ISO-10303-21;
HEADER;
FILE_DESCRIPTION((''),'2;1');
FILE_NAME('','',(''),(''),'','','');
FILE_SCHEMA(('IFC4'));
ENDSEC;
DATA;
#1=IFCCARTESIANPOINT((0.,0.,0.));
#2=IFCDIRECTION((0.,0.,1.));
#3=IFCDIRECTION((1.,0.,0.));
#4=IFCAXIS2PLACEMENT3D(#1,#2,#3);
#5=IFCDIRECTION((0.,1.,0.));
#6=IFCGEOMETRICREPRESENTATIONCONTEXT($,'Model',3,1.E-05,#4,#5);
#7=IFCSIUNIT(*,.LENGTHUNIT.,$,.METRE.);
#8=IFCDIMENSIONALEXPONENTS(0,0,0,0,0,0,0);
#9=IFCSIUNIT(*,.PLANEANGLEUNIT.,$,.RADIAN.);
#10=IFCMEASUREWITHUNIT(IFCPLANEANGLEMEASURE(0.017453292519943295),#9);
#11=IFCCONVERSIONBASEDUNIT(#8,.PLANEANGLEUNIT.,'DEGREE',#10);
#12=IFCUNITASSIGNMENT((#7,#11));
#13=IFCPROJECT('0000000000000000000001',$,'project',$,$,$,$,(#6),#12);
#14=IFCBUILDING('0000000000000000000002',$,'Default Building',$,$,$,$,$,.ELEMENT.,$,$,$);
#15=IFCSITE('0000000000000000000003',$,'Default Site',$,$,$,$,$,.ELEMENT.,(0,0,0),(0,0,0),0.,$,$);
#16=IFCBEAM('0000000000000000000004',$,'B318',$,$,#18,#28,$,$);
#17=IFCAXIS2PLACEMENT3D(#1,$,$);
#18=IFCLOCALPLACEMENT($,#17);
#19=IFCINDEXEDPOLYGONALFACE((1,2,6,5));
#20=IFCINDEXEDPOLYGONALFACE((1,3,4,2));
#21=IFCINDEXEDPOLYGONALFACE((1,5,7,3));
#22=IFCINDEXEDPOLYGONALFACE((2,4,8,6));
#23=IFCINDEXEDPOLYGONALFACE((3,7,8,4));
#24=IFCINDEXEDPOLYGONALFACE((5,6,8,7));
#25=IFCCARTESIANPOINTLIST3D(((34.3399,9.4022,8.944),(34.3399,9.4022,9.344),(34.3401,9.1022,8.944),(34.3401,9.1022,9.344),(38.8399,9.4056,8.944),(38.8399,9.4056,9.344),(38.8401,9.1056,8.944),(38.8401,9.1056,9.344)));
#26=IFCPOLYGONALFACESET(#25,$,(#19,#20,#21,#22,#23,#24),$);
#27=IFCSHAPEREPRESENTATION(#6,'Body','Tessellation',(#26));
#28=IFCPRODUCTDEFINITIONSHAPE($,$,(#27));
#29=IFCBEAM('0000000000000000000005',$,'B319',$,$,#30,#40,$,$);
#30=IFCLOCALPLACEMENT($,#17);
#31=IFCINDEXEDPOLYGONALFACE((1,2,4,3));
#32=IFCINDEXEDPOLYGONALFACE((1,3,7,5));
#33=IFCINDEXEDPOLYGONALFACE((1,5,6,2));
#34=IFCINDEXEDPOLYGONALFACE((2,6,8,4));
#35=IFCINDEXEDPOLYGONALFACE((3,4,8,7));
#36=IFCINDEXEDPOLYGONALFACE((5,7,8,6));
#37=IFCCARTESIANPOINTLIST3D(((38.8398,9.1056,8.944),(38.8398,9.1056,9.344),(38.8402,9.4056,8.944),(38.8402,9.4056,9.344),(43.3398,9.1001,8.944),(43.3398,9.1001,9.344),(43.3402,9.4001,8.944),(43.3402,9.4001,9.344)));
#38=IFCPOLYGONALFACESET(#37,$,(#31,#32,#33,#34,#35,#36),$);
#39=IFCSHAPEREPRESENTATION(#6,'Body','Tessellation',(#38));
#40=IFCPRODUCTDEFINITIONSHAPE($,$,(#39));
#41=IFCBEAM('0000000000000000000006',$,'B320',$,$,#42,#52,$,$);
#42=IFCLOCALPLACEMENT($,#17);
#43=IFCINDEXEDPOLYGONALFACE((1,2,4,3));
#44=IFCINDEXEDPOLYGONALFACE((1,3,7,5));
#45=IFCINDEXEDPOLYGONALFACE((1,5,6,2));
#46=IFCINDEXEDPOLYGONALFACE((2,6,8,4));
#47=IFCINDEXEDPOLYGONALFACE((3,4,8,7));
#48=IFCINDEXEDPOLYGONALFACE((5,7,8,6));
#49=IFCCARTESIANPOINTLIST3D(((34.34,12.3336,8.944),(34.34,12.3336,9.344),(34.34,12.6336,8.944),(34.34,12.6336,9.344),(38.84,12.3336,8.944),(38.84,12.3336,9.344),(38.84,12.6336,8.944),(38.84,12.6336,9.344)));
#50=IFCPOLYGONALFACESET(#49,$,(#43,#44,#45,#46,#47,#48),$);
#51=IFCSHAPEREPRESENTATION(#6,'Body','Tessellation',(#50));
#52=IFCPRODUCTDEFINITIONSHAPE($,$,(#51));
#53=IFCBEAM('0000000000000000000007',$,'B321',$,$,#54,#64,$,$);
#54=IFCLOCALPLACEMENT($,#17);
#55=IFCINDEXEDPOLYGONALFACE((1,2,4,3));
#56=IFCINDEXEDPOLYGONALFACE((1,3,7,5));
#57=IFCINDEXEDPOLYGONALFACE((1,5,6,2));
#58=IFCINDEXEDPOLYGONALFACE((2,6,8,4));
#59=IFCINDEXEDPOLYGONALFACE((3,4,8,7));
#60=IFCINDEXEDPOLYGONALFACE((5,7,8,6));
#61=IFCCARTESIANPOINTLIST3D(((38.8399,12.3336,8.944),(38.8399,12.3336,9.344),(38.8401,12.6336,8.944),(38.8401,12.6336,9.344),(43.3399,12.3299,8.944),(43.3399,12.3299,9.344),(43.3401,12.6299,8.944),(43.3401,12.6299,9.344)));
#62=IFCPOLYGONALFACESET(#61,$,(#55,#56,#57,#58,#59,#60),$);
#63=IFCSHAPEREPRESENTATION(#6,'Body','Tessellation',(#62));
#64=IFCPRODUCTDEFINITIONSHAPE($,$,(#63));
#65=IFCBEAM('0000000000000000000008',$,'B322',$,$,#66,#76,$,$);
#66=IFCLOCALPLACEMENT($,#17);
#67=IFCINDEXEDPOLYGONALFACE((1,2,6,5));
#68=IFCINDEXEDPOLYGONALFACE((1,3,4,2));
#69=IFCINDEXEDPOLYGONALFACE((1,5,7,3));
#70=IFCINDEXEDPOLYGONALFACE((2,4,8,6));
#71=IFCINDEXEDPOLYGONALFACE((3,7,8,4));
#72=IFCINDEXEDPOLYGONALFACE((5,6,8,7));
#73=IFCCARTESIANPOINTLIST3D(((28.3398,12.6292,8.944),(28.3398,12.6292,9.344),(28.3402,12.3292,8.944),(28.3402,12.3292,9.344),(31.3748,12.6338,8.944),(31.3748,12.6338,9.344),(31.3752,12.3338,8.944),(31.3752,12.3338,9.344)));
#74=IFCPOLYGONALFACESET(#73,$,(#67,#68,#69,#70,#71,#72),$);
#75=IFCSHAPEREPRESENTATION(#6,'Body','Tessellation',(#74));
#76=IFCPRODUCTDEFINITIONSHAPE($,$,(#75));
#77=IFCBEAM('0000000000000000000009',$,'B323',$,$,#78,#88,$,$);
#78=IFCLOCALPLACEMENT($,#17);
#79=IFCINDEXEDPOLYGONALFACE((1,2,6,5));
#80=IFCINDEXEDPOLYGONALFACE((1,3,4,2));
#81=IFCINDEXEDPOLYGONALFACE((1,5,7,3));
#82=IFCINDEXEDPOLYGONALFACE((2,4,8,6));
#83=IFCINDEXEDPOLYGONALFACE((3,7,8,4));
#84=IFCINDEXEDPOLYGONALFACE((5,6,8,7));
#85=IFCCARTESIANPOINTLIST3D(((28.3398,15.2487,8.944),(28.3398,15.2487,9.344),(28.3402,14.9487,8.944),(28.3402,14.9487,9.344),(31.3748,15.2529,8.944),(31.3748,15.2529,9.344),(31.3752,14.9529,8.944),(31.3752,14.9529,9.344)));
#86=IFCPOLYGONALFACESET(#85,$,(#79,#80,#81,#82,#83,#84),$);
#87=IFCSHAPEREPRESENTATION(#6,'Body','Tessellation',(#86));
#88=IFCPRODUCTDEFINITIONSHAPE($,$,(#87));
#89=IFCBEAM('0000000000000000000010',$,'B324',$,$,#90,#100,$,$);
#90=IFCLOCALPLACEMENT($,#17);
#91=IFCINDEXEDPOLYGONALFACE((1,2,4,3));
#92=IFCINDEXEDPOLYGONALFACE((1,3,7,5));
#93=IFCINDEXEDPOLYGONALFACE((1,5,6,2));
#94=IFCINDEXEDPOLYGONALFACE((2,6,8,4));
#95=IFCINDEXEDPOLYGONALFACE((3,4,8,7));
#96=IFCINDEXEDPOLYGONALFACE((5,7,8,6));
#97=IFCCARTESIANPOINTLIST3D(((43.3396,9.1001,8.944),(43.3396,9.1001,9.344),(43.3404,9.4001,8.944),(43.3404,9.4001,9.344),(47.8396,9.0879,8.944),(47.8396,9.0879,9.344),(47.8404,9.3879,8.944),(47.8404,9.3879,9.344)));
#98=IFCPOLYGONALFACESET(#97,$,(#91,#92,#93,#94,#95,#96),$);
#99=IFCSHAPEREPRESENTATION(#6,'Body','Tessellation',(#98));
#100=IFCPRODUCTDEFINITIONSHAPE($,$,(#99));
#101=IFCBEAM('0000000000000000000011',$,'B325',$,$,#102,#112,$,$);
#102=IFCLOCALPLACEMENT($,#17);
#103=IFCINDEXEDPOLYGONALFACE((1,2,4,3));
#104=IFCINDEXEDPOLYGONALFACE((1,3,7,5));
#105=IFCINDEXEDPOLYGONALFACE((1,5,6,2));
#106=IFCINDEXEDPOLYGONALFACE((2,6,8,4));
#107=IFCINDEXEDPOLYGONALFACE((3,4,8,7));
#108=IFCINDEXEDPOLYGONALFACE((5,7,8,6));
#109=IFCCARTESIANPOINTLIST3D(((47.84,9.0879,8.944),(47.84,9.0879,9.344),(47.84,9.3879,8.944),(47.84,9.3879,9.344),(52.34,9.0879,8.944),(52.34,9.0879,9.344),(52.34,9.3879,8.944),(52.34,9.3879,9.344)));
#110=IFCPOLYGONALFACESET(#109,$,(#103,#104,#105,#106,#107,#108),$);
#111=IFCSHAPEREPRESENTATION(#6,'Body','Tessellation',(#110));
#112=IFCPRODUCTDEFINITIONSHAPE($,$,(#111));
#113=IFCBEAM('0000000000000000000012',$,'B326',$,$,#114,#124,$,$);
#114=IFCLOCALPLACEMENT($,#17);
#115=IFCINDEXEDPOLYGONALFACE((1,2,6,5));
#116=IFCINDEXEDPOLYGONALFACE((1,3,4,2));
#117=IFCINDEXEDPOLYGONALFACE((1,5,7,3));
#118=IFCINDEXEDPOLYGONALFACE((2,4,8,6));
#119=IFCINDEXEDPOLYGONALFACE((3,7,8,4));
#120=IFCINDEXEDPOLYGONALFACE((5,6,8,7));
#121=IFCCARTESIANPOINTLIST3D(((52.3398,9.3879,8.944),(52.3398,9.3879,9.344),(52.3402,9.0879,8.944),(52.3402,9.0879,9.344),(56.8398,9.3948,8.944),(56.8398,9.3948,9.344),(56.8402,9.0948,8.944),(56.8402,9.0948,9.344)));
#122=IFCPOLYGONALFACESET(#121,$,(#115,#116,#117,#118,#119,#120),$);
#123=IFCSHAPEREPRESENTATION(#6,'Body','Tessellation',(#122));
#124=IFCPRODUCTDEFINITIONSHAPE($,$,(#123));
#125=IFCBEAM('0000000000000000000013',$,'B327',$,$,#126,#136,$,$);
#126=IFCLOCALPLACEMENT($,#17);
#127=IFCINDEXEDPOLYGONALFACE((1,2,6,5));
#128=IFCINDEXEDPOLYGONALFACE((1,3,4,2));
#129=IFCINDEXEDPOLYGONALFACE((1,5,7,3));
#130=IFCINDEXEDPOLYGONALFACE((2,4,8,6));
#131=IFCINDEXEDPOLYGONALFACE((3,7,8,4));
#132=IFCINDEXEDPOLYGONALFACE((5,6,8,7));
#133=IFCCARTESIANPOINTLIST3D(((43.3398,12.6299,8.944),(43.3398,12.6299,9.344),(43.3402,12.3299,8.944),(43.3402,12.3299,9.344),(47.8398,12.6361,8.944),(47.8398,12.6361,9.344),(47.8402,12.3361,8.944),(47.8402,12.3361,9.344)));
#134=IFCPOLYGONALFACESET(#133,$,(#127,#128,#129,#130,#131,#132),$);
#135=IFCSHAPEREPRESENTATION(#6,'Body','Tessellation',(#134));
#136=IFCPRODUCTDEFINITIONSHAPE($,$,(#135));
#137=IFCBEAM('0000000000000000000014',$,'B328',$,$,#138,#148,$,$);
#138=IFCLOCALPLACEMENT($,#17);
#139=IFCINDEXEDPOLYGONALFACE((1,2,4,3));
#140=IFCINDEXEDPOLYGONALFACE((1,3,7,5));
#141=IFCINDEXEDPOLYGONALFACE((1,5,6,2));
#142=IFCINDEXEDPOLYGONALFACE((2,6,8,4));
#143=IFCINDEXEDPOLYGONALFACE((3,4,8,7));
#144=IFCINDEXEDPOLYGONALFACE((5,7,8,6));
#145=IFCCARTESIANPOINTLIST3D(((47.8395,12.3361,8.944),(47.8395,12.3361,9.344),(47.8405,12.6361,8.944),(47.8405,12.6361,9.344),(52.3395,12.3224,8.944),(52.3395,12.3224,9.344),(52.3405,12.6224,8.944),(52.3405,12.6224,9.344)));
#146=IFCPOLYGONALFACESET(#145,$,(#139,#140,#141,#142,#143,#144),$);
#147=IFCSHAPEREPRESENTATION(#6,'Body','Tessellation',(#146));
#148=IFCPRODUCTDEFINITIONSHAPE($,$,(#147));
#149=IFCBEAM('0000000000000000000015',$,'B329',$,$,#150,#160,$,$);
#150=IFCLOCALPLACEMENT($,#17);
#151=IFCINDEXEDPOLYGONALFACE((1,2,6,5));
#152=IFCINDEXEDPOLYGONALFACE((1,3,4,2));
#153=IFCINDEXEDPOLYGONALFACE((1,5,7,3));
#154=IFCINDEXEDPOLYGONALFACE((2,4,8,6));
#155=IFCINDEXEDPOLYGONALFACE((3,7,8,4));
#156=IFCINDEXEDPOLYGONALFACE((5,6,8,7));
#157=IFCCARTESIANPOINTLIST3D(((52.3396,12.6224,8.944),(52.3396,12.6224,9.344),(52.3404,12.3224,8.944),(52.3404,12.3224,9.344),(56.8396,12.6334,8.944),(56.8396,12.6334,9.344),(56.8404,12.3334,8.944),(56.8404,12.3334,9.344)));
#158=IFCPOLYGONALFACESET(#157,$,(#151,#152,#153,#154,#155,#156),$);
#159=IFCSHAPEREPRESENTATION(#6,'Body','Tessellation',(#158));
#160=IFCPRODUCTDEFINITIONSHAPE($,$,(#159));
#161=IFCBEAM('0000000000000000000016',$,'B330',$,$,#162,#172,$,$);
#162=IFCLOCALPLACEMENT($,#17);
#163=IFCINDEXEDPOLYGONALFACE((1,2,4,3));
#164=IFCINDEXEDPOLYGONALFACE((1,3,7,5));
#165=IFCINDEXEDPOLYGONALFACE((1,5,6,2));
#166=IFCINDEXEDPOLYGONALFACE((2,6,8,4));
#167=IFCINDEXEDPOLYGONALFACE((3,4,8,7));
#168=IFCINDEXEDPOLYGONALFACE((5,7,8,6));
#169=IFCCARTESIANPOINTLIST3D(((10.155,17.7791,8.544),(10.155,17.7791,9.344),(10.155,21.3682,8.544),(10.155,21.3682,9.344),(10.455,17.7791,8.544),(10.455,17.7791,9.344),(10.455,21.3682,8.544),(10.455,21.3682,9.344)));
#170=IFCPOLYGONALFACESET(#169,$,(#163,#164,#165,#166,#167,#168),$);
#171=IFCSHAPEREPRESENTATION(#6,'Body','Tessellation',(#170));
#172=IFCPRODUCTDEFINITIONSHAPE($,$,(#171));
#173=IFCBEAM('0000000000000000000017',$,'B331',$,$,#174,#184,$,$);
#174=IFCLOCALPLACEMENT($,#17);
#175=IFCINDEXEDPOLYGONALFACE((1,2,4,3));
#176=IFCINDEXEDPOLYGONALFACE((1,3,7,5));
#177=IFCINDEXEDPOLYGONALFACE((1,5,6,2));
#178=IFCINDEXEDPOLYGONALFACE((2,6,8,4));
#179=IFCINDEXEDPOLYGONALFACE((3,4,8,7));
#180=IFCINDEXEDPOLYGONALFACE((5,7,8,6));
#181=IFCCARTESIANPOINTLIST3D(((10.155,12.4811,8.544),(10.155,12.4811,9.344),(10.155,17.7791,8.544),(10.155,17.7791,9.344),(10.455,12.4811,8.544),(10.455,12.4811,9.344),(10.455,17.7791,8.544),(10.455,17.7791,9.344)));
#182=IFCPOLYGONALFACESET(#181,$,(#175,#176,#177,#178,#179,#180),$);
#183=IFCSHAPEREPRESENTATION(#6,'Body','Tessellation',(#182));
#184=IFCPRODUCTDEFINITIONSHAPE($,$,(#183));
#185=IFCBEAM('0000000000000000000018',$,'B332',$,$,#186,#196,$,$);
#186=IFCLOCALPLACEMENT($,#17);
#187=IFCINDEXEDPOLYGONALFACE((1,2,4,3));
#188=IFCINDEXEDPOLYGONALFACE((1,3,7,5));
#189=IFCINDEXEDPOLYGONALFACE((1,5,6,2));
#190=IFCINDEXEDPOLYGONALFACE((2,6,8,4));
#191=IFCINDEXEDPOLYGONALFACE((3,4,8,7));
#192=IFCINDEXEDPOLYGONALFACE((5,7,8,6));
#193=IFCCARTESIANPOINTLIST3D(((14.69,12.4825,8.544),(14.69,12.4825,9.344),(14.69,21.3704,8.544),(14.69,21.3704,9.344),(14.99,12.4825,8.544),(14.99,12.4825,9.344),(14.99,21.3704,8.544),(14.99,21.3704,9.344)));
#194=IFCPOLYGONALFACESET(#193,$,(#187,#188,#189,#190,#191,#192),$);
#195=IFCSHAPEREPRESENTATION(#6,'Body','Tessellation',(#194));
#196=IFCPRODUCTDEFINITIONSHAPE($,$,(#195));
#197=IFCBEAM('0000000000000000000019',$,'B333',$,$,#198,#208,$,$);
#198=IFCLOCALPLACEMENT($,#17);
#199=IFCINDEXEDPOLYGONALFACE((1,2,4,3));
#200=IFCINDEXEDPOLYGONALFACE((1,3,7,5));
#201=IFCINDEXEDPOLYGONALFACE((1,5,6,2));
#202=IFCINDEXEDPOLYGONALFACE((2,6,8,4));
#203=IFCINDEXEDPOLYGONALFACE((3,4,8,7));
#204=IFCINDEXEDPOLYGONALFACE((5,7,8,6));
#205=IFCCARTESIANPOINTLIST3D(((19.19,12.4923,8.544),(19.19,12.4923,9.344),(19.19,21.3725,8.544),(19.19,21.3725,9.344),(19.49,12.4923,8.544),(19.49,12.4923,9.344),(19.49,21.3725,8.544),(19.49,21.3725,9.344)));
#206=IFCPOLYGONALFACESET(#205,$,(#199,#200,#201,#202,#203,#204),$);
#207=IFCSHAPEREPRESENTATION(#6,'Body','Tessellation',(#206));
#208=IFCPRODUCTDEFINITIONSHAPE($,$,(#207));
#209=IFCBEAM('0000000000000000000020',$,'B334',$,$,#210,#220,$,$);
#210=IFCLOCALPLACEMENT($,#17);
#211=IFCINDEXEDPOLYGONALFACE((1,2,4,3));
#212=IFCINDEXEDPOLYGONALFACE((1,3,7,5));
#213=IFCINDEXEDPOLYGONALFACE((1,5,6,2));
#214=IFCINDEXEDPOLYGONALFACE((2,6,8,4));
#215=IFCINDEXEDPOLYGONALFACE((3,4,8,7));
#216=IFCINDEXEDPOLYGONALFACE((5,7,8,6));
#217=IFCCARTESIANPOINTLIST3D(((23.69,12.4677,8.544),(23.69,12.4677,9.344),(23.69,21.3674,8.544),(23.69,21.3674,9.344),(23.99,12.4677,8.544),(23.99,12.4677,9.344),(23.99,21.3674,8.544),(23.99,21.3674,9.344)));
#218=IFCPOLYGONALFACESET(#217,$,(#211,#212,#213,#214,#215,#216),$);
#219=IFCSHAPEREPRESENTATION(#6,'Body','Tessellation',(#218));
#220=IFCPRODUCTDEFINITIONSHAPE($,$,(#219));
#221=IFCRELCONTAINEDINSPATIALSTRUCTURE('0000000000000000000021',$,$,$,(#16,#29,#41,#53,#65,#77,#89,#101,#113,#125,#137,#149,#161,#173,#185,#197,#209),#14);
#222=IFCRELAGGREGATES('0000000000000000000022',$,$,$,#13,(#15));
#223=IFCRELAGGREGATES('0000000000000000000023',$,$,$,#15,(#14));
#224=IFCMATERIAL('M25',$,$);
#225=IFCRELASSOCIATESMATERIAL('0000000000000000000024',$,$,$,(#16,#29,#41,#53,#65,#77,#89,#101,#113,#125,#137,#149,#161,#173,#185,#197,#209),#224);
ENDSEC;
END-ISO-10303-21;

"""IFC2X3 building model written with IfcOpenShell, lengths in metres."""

from ifc_helpers import new_model, entity, si_unit, converted_unit, direction, frame, frame_2d, origin_with_axes, place, context, project, spatial, rectangle, extrude, material, element, save


model = new_model("IFC2X3")

# Units and contexts
model_context = context("Model", 3, precision=1e-05, world=origin_with_axes(), true_north=direction((0.0, 1.0, 0.0)))
ifc_project = project(units=[si_unit("LENGTHUNIT", "METRE"), converted_unit("PLANEANGLEUNIT", "DEGREE", entity("IfcPlaneAngleMeasure", 0.017453292519943295), si_unit("PLANEANGLEUNIT", "RADIAN"), dimensions=[0, 0, 0, 0, 0, 0, 0])], contexts=[model_context])

# Site, building
site = spatial("IfcSite", under=ifc_project, Name="Default Site", CompositionType="ELEMENT", RefLatitude=(0, 0, 0), RefLongitude=(0, 0, 0), RefElevation=0.0)
building = spatial("IfcBuilding", under=site, Name="Default Building", CompositionType="ELEMENT")

# Beams
ifc_material = material(Name="M25")
placement = place(None, origin_with_axes())
element("IfcBeam", 1, at=placement, inside=building, material=ifc_material, Name="B318", context=model_context, shape_type="SweptSolid", body=[
    extrude(rectangle(XDim=0.3, YDim=0.4, at=frame_2d((0.0, 0.0), x_axis=(0.0, 1.0, 0.0))), frame((34.34, 9.2522, 9.144), z_axis=(1.0, 0.000748, 0.0), x_axis=(0.0, 0.0, -1.0)), (0.0, 0.0, 1.0), 4.5),
])
element("IfcBeam", 2, at=placement, inside=building, material=ifc_material, Name="B319", context=model_context, shape_type="SweptSolid", body=[
    extrude(rectangle(XDim=0.3, YDim=0.4, at=frame_2d((0.0, 0.0), x_axis=(0.0, 1.0, 0.0))), frame((38.84, 9.2556, 9.144), z_axis=(0.999999, -0.001227, 0.0), x_axis=(0.0, 0.0, -1.0)), (0.0, 0.0, 1.0), 4.5),
])
element("IfcBeam", 3, at=placement, inside=building, material=ifc_material, Name="B320", context=model_context, shape_type="SweptSolid", body=[
    extrude(rectangle(XDim=0.3, YDim=0.4, at=frame_2d((0.0, 0.0), x_axis=(0.0, 1.0, 0.0))), frame((34.34, 12.4836, 9.144), z_axis=(1.0, -0.000008, 0.0), x_axis=(0.0, 0.0, -1.0)), (0.0, 0.0, 1.0), 4.5),
])
element("IfcBeam", 4, at=placement, inside=building, material=ifc_material, Name="B321", context=model_context, shape_type="SweptSolid", body=[
    extrude(rectangle(XDim=0.3, YDim=0.4, at=frame_2d((0.0, 0.0), x_axis=(0.0, 1.0, 0.0))), frame((38.84, 12.4836, 9.144), z_axis=(1.0, -0.000826, 0.0), x_axis=(0.0, 0.0, -1.0)), (0.0, 0.0, 1.0), 4.5),
])
element("IfcBeam", 5, at=placement, inside=building, material=ifc_material, Name="B322", context=model_context, shape_type="SweptSolid", body=[
    extrude(rectangle(XDim=0.3, YDim=0.4, at=frame_2d((0.0, 0.0), x_axis=(0.0, 1.0, 0.0))), frame((28.34, 12.4792, 9.144), z_axis=(0.999999, 0.001542, 0.0), x_axis=(0.0, 0.0, -1.0)), (0.0, 0.0, 1.0), 3.035),
])
element("IfcBeam", 6, at=placement, inside=building, material=ifc_material, Name="B323", context=model_context, shape_type="SweptSolid", body=[
    extrude(rectangle(XDim=0.3, YDim=0.4, at=frame_2d((0.0, 0.0), x_axis=(0.0, 1.0, 0.0))), frame((31.375, 15.1029, 9.144), z_axis=(-0.999999, -0.001391, 0.0), x_axis=(0.0, 0.0, -1.0)), (0.0, 0.0, 1.0), 3.035),
])
element("IfcBeam", 7, at=placement, inside=building, material=ifc_material, Name="B324", context=model_context, shape_type="SweptSolid", body=[
    extrude(rectangle(XDim=0.3, YDim=0.4, at=frame_2d((0.0, 0.0), x_axis=(0.0, 1.0, 0.0))), frame((43.34, 9.2501, 9.144), z_axis=(0.999996, -0.002702, 0.0), x_axis=(0.0, 0.0, -1.0)), (0.0, 0.0, 1.0), 4.5),
])
element("IfcBeam", 8, at=placement, inside=building, material=ifc_material, Name="B325", context=model_context, shape_type="SweptSolid", body=[
    extrude(rectangle(XDim=0.3, YDim=0.4, at=frame_2d((0.0, 0.0), x_axis=(0.0, 1.0, 0.0))), frame((47.84, 9.2379, 9.144), z_axis=(1.0, 0.0, 0.0), x_axis=(0.0, 0.0, -1.0)), (0.0, 0.0, 1.0), 4.5),
])
element("IfcBeam", 9, at=placement, inside=building, material=ifc_material, Name="B326", context=model_context, shape_type="SweptSolid", body=[
    extrude(rectangle(XDim=0.3, YDim=0.4, at=frame_2d((0.0, 0.0), x_axis=(0.0, 1.0, 0.0))), frame((52.34, 9.2379, 9.144), z_axis=(0.999999, 0.001537, 0.0), x_axis=(0.0, 0.0, -1.0)), (0.0, 0.0, 1.0), 4.5),
])
element("IfcBeam", 10, at=placement, inside=building, material=ifc_material, Name="B327", context=model_context, shape_type="SweptSolid", body=[
    extrude(rectangle(XDim=0.3, YDim=0.4, at=frame_2d((0.0, 0.0), x_axis=(0.0, 1.0, 0.0))), frame((43.34, 12.4799, 9.144), z_axis=(0.999999, 0.001374, 0.0), x_axis=(0.0, 0.0, -1.0)), (0.0, 0.0, 1.0), 4.5),
])
element("IfcBeam", 11, at=placement, inside=building, material=ifc_material, Name="B328", context=model_context, shape_type="SweptSolid", body=[
    extrude(rectangle(XDim=0.3, YDim=0.4, at=frame_2d((0.0, 0.0), x_axis=(0.0, 1.0, 0.0))), frame((47.84, 12.4861, 9.144), z_axis=(0.999995, -0.003045, 0.0), x_axis=(0.0, 0.0, -1.0)), (0.0, 0.0, 1.0), 4.5),
])
element("IfcBeam", 12, at=placement, inside=building, material=ifc_material, Name="B329", context=model_context, shape_type="SweptSolid", body=[
    extrude(rectangle(XDim=0.3, YDim=0.4, at=frame_2d((0.0, 0.0), x_axis=(0.0, 1.0, 0.0))), frame((52.34, 12.4724, 9.144), z_axis=(0.999997, 0.002456, 0.0), x_axis=(0.0, 0.0, -1.0)), (0.0, 0.0, 1.0), 4.5),
])
element("IfcBeam", 13, at=placement, inside=building, material=ifc_material, Name="B330", context=model_context, shape_type="SweptSolid", body=[
    extrude(rectangle(XDim=0.3, YDim=0.8, at=frame_2d((0.0, 0.0), x_axis=(0.0, 1.0, 0.0))), frame((10.305, 21.3682, 8.944), z_axis=(0.0, -1.0, 0.0), x_axis=(0.0, 0.0, -1.0)), (0.0, 0.0, 1.0), 3.5891),
])
element("IfcBeam", 14, at=placement, inside=building, material=ifc_material, Name="B331", context=model_context, shape_type="SweptSolid", body=[
    extrude(rectangle(XDim=0.3, YDim=0.8, at=frame_2d((0.0, 0.0), x_axis=(0.0, 1.0, 0.0))), frame((10.305, 17.7791, 8.944), z_axis=(0.0, -1.0, 0.0), x_axis=(0.0, 0.0, -1.0)), (0.0, 0.0, 1.0), 5.298),
])
element("IfcBeam", 15, at=placement, inside=building, material=ifc_material, Name="B332", context=model_context, shape_type="SweptSolid", body=[
    extrude(rectangle(XDim=0.3, YDim=0.8, at=frame_2d((0.0, 0.0), x_axis=(0.0, 1.0, 0.0))), frame((14.84, 21.3704, 8.944), z_axis=(0.0, -1.0, 0.0), x_axis=(0.0, 0.0, -1.0)), (0.0, 0.0, 1.0), 8.8879),
])
element("IfcBeam", 16, at=placement, inside=building, material=ifc_material, Name="B333", context=model_context, shape_type="SweptSolid", body=[
    extrude(rectangle(XDim=0.3, YDim=0.8, at=frame_2d((0.0, 0.0), x_axis=(0.0, 1.0, 0.0))), frame((19.34, 21.3725, 8.944), z_axis=(0.0, -1.0, 0.0), x_axis=(0.0, 0.0, -1.0)), (0.0, 0.0, 1.0), 8.8802),
])
element("IfcBeam", 17, at=placement, inside=building, material=ifc_material, Name="B334", context=model_context, shape_type="SweptSolid", body=[
    extrude(rectangle(XDim=0.3, YDim=0.8, at=frame_2d((0.0, 0.0), x_axis=(0.0, 1.0, 0.0))), frame((23.84, 21.3674, 8.944), z_axis=(0.0, -1.0, 0.0), x_axis=(0.0, 0.0, -1.0)), (0.0, 0.0, 1.0), 8.8997),
])

save(model, "model.ifc")
